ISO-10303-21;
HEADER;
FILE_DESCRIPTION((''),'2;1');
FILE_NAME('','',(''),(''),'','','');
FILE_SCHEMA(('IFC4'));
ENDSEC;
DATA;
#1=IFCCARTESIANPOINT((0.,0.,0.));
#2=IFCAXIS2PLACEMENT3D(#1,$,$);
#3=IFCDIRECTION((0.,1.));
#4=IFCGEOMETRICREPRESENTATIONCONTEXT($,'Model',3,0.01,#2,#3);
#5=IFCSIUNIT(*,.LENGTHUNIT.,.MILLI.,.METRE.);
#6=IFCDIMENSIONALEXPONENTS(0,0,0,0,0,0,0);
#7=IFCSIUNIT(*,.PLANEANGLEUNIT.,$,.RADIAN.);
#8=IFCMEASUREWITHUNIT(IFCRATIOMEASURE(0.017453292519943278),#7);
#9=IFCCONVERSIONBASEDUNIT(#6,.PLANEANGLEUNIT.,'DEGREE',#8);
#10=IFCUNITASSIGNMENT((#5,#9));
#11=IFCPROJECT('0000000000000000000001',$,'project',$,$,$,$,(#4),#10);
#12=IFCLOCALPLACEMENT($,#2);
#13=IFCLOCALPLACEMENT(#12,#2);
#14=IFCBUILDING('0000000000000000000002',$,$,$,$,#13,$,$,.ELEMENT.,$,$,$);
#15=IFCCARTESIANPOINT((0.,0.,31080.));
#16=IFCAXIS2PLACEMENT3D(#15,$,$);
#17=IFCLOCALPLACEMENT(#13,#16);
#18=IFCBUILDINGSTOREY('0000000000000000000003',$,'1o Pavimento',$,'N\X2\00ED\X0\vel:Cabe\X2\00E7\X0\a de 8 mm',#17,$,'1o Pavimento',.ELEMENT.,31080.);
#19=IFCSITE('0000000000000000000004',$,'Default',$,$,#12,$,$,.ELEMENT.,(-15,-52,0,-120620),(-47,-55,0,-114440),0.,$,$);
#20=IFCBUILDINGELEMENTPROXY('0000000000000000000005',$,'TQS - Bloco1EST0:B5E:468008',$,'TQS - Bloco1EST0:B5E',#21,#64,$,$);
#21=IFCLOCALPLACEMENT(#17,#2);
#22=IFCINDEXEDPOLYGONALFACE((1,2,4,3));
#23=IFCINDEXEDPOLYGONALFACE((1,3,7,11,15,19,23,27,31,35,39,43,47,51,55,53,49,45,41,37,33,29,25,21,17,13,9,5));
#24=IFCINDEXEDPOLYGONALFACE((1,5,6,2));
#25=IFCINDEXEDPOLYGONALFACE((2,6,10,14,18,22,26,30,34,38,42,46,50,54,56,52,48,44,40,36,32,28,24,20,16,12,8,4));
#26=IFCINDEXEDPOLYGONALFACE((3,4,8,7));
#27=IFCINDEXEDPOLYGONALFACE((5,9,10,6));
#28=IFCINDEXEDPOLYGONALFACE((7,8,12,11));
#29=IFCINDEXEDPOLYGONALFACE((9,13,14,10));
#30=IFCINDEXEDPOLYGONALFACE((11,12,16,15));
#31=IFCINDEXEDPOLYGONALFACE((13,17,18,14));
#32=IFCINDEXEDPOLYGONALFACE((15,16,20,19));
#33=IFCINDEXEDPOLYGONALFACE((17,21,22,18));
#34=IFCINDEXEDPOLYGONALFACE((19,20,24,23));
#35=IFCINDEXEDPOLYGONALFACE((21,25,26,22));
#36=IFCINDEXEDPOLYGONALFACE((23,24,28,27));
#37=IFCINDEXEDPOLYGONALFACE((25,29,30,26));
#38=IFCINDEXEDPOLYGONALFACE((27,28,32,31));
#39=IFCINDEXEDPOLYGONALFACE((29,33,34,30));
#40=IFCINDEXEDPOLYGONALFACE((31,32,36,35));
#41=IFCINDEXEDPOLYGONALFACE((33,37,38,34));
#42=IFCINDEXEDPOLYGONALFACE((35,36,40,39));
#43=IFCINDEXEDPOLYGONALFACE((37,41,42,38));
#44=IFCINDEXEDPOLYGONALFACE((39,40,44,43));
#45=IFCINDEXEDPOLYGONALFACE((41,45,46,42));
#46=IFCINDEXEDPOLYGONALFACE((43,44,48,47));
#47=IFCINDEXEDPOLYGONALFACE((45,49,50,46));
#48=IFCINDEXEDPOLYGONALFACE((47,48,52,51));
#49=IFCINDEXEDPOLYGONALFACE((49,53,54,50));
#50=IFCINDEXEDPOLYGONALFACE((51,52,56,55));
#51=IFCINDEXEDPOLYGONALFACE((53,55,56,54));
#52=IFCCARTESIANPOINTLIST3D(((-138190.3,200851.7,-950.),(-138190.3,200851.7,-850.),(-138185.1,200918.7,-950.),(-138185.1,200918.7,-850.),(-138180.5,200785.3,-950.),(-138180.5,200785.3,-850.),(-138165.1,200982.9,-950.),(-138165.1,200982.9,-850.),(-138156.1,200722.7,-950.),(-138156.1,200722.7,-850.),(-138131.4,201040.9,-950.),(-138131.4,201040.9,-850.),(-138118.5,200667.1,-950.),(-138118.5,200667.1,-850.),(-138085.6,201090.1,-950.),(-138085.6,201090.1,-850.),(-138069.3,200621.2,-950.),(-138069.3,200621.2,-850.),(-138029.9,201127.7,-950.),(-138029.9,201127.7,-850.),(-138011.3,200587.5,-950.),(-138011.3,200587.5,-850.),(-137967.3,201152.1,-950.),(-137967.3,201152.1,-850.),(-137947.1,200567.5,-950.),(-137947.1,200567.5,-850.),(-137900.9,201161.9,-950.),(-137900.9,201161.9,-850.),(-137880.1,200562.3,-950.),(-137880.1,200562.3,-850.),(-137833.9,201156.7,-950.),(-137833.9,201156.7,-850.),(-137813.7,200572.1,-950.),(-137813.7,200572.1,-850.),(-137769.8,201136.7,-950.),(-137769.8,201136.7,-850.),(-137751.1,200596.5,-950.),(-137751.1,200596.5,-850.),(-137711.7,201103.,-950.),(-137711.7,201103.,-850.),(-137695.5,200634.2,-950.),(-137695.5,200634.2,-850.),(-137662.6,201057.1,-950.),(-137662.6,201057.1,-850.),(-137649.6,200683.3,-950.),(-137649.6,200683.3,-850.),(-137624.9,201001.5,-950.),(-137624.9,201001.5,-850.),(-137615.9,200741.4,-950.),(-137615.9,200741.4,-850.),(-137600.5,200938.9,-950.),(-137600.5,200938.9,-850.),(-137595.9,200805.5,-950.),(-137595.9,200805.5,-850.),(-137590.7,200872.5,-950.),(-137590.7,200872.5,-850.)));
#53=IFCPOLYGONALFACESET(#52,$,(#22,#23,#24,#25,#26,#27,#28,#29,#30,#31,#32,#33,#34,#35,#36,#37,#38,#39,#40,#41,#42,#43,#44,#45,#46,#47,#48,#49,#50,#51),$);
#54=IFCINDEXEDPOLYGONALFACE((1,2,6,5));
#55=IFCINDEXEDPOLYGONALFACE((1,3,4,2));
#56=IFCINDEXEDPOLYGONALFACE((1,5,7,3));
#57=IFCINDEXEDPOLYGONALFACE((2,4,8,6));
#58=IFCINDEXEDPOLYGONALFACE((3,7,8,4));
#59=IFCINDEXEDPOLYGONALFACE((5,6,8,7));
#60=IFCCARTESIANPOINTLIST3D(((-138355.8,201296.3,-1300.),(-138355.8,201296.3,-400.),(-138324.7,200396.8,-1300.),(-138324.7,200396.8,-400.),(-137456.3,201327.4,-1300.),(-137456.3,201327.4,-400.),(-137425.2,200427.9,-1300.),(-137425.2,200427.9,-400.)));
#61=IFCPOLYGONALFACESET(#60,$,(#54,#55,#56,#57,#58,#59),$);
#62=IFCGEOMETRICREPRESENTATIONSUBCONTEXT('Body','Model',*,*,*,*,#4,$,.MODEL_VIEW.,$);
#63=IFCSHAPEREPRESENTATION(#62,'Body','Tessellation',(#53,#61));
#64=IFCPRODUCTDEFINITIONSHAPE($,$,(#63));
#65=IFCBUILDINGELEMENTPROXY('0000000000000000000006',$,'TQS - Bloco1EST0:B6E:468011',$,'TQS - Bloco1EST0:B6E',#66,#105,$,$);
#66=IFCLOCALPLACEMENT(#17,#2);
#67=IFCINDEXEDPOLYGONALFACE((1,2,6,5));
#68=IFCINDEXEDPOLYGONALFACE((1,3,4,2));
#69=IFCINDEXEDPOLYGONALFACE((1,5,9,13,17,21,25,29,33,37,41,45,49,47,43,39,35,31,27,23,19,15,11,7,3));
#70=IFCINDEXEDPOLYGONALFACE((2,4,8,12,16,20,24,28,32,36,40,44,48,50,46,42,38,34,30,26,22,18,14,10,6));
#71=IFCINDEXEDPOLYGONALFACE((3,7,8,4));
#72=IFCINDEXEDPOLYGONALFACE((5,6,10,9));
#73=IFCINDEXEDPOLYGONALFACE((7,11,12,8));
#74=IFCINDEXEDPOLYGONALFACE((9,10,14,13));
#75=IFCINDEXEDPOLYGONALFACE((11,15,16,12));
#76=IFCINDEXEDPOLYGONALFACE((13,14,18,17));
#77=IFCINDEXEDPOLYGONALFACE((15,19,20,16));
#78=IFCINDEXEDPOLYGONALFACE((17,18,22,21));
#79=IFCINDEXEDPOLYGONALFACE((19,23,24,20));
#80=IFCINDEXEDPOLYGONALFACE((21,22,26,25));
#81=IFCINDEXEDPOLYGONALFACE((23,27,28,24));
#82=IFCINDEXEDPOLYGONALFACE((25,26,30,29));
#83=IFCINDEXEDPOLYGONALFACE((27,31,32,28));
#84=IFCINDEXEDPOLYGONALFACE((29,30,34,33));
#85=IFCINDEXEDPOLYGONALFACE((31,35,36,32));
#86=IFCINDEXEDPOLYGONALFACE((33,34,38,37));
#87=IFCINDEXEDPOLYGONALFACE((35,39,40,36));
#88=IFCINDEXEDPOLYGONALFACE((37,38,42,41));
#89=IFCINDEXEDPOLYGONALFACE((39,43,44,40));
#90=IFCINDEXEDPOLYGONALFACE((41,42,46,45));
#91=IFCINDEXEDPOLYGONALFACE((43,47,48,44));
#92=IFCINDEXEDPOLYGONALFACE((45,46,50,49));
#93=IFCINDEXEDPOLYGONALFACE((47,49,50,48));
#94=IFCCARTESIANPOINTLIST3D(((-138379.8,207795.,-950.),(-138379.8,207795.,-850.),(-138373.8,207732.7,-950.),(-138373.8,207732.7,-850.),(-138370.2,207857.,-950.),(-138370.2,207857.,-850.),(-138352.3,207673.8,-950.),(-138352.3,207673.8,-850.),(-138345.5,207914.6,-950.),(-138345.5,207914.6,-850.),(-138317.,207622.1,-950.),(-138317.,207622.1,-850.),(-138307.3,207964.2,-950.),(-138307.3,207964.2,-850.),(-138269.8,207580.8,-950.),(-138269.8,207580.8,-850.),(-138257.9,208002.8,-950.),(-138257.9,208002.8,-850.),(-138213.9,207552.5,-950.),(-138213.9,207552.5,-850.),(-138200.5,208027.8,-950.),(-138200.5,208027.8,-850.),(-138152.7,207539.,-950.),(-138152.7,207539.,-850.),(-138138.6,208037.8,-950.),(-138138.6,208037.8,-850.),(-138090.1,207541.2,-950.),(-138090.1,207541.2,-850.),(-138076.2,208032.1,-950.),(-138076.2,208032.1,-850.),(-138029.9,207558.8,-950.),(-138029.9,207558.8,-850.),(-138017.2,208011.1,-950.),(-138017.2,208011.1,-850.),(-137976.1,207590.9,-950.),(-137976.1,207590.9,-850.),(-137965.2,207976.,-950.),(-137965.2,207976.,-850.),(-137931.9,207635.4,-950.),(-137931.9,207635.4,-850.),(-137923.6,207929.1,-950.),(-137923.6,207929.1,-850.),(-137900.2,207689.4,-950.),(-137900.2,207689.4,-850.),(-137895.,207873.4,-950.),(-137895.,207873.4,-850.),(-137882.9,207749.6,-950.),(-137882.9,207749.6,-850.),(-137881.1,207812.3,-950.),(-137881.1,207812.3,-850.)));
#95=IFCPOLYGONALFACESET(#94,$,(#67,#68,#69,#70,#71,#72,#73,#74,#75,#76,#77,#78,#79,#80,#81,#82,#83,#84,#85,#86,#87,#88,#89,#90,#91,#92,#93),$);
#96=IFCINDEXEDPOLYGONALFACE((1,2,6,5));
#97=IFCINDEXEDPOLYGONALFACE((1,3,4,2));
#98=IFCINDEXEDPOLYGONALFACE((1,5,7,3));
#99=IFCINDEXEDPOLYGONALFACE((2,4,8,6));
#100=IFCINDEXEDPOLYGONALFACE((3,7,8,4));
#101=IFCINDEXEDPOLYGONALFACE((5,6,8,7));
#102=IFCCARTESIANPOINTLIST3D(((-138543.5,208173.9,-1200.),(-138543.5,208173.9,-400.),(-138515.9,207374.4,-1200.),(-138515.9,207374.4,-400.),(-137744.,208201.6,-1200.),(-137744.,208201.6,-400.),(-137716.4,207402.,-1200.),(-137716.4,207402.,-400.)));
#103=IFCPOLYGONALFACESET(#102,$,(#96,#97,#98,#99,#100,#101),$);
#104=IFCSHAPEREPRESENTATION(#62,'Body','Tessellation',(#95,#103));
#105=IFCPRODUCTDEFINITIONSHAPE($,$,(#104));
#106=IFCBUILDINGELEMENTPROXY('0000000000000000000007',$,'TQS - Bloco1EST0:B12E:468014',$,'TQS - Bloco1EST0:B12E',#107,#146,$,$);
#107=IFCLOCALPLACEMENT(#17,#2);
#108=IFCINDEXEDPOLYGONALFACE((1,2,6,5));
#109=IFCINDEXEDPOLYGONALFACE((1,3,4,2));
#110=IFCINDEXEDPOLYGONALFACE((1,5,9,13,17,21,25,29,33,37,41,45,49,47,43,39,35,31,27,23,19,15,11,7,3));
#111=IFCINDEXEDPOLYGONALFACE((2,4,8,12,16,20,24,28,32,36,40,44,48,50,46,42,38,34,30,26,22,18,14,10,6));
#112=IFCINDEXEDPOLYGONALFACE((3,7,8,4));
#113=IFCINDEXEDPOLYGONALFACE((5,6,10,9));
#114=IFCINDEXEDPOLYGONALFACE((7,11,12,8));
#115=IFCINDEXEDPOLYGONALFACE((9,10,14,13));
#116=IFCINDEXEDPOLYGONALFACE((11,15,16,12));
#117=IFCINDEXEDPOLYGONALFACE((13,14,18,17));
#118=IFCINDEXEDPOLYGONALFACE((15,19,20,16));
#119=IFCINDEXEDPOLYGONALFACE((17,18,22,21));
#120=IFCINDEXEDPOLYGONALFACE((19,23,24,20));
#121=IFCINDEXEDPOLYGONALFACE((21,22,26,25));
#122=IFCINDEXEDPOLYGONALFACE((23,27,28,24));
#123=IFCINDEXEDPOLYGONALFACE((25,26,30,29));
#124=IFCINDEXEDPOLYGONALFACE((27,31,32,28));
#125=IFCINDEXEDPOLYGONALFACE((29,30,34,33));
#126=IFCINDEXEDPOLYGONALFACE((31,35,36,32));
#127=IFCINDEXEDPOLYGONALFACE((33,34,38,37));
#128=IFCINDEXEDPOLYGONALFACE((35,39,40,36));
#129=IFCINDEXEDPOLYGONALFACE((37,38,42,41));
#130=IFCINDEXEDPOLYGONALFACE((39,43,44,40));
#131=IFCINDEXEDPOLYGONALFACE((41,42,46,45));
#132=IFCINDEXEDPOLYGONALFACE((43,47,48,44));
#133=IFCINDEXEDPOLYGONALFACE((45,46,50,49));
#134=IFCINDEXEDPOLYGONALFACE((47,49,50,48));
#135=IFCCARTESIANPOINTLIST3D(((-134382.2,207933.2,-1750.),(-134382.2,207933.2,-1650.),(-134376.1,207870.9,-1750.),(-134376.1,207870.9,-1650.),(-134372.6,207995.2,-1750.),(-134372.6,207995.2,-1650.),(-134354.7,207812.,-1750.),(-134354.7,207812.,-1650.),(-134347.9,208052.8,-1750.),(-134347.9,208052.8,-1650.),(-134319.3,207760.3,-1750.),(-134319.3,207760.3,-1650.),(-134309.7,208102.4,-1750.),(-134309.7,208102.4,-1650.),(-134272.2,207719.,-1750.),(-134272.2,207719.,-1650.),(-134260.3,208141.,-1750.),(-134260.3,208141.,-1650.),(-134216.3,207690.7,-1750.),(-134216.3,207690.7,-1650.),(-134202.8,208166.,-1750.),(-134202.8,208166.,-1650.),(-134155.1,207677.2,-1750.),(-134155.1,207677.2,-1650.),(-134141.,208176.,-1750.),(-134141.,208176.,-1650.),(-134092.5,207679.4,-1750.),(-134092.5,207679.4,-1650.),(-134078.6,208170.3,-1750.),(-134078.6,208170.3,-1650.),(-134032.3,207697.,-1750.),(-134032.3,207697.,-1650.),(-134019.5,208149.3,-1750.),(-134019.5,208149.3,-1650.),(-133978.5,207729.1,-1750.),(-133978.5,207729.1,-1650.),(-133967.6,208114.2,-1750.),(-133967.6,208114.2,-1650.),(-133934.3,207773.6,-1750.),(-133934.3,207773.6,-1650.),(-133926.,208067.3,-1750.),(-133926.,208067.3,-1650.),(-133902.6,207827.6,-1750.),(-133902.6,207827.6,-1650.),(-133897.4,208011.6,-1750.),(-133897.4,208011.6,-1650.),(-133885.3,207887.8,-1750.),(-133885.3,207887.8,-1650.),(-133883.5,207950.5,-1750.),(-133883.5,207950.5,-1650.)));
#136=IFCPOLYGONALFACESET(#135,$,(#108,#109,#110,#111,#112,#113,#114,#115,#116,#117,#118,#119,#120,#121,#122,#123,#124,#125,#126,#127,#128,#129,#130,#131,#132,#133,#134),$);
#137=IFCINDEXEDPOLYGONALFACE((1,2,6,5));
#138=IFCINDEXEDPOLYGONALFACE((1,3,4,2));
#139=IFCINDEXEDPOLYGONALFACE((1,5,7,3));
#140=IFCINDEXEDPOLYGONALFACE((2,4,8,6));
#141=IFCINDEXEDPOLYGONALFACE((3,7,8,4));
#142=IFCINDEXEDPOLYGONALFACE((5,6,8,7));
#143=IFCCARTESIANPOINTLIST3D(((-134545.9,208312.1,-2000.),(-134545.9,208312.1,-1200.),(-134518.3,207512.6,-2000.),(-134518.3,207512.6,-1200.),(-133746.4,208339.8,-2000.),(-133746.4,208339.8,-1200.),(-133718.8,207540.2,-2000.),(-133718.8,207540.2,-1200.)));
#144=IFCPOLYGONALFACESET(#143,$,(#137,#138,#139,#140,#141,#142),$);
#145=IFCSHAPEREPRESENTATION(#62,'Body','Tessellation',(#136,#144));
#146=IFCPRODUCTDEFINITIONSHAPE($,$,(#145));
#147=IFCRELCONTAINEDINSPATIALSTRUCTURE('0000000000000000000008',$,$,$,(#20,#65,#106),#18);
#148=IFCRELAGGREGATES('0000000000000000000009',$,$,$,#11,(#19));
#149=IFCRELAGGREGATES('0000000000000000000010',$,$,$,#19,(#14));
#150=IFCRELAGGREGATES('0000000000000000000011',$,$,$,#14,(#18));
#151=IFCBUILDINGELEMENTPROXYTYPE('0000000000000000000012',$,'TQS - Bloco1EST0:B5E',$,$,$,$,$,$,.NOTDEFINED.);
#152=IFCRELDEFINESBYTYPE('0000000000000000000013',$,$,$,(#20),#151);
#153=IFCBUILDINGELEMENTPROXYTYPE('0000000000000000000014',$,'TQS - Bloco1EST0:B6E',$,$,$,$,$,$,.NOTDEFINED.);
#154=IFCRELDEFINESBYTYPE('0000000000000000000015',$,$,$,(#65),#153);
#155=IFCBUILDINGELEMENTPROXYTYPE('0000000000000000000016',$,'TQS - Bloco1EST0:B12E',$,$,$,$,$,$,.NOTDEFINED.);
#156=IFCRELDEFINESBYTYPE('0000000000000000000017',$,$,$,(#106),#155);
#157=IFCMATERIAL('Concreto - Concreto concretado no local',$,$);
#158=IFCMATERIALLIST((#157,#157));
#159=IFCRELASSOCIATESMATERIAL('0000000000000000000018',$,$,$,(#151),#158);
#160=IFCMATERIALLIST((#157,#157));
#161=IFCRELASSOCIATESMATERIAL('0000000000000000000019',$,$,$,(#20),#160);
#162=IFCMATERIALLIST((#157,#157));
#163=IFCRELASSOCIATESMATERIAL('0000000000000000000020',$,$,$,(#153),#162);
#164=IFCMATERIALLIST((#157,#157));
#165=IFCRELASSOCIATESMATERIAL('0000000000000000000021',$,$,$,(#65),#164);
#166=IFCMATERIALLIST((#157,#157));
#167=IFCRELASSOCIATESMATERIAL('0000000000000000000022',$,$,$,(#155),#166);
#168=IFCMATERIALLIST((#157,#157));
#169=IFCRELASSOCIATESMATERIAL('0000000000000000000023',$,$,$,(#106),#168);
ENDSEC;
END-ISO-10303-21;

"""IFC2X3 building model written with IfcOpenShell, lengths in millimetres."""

from ifc_helpers import new_model, entity, si_unit, converted_unit, direction, frame, frame_2d, origin, origin_2d_with_axis, place, context, subcontext, project, spatial, rectangle, circle, extrude, source, transform, mapped, material, material_list, type_object, type_shapes, element, save


model = new_model("IFC2X3")

# Units and contexts
model_context = context("Model", 3, precision=0.01, world=origin(), true_north=direction((0.0, 1.0)))
body_context = subcontext(model_context, "Body", "Model", "MODEL_VIEW")
ifc_project = project(units=[si_unit("LENGTHUNIT", "METRE", prefix="MILLI"), converted_unit("PLANEANGLEUNIT", "DEGREE", entity("IfcRatioMeasure", 0.017453292519943278), si_unit("PLANEANGLEUNIT", "RADIAN"), dimensions=[0, 0, 0, 0, 0, 0, 0])], contexts=[model_context])

# Site, building, storey
site_placement = place(None, origin())
site = spatial("IfcSite", under=ifc_project, at=site_placement, Name="Default", CompositionType="ELEMENT", RefLatitude=(-15, -52, 0, -120620), RefLongitude=(-47, -55, 0, -114440), RefElevation=0.0)
building_placement = place(site_placement, origin())
building = spatial("IfcBuilding", under=site, at=building_placement, CompositionType="ELEMENT")
storey_placement = place(building_placement, frame((0.0, 0.0, 31080.0)))
storey = spatial("IfcBuildingStorey", under=building, at=storey_placement, Name="1o Pavimento", ObjectType="Nível:Cabeça de 8 mm", LongName="1o Pavimento", CompositionType="ELEMENT", Elevation=31080.0)

# Building element proxies
ifc_material_1 = material(Name="Concreto - Concreto concretado no local")
ifc_material_list_1 = material_list([ifc_material_1, ifc_material_1])
ifc_material_list_2 = material_list([ifc_material_1, ifc_material_1])
building_element_proxy_type_1 = type_object("IfcBuildingElementProxyType", Name="TQS - Bloco1EST0:B5E", PredefinedType="NOTDEFINED", material=ifc_material_list_2)
shared_shape_1 = source(origin(), body_context, "Body", "SweptSolid", [
    extrude(circle(Radius=300.0, at=frame_2d((0.0, 0.0), x_axis=(1.0, 0.0))), frame((0.0, 0.0, -550.0)), (0.0, 0.0, 1.0), 100.0),
    extrude(rectangle(XDim=900.0, YDim=900.0, at=origin_2d_with_axis()), frame((0.0, 0.0, -900.0), z_axis=(0.0, 0.0, 1.0), x_axis=(-1.0, 0.0, 0.0)), (0.0, 0.0, 1.0), 900.0),
])
type_shapes(building_element_proxy_type_1, [shared_shape_1])
proxy_1_placement = place(storey_placement, frame((-137890.5, 200862.1, -400.0), z_axis=(0.0, 0.0, 1.0), x_axis=(-0.034551, 0.999403, 0.0)))
element("IfcBuildingElementProxy", 1, at=proxy_1_placement, inside=storey, type_object=building_element_proxy_type_1, material=ifc_material_list_1, Name="TQS - Bloco1EST0:B5E:468008", ObjectType="TQS - Bloco1EST0:B5E", context=body_context, shape_type="MappedRepresentation", body=[
    mapped(shared_shape_1, transform((0.0, 0.0, 0.0), scale=1.0)),
])
ifc_material_list_3 = material_list([ifc_material_1, ifc_material_1])
ifc_material_list_4 = material_list([ifc_material_1, ifc_material_1])
building_element_proxy_type_2 = type_object("IfcBuildingElementProxyType", Name="TQS - Bloco1EST0:B6E", PredefinedType="NOTDEFINED", material=ifc_material_list_4)
shared_shape_2 = source(origin(), body_context, "Body", "SweptSolid", [
    extrude(circle(Radius=250.0, at=frame_2d((0.0, 0.0), x_axis=(1.0, 0.0))), frame((0.0, 0.0, -550.0)), (0.0, 0.0, 1.0), 100.0),
    extrude(rectangle(XDim=800.0, YDim=800.0, at=origin_2d_with_axis()), frame((0.0, 0.0, -800.0), z_axis=(0.0, 0.0, 1.0), x_axis=(-1.0, 0.0, 0.0)), (0.0, 0.0, 1.0), 800.0),
])
type_shapes(building_element_proxy_type_2, [shared_shape_2])
proxy_2_placement = place(storey_placement, frame((-138129.9, 207788.0, -400.0), z_axis=(0.0, 0.0, 1.0), x_axis=(-0.034551, 0.999403, 0.0)))
element("IfcBuildingElementProxy", 2, at=proxy_2_placement, inside=storey, type_object=building_element_proxy_type_2, material=ifc_material_list_3, Name="TQS - Bloco1EST0:B6E:468011", ObjectType="TQS - Bloco1EST0:B6E", context=body_context, shape_type="MappedRepresentation", body=[
    mapped(shared_shape_2, transform((0.0, 0.0, 0.0), scale=1.0)),
])
ifc_material_list_5 = material_list([ifc_material_1, ifc_material_1])
ifc_material_list_6 = material_list([ifc_material_1, ifc_material_1])
building_element_proxy_type_3 = type_object("IfcBuildingElementProxyType", Name="TQS - Bloco1EST0:B12E", PredefinedType="NOTDEFINED", material=ifc_material_list_6)
shared_shape_3 = source(origin(), body_context, "Body", "SweptSolid", [
    extrude(circle(Radius=250.0, at=frame_2d((0.0, 0.0), x_axis=(1.0, 0.0))), frame((0.0, 0.0, -550.0)), (0.0, 0.0, 1.0), 100.0),
    extrude(rectangle(XDim=800.0, YDim=800.0, at=origin_2d_with_axis()), frame((0.0, 0.0, -800.0), z_axis=(0.0, 0.0, 1.0), x_axis=(-1.0, 0.0, 0.0)), (0.0, 0.0, 1.0), 800.0),
])
type_shapes(building_element_proxy_type_3, [shared_shape_3])
proxy_3_placement = place(storey_placement, frame((-134132.3, 207926.2, -1200.0), z_axis=(0.0, 0.0, 1.0), x_axis=(-0.034551, 0.999403, 0.0)))
element("IfcBuildingElementProxy", 3, at=proxy_3_placement, inside=storey, type_object=building_element_proxy_type_3, material=ifc_material_list_5, Name="TQS - Bloco1EST0:B12E:468014", ObjectType="TQS - Bloco1EST0:B12E", context=body_context, shape_type="MappedRepresentation", body=[
    mapped(shared_shape_3, transform((0.0, 0.0, 0.0), scale=1.0)),
])

save(model, "model.ifc")
